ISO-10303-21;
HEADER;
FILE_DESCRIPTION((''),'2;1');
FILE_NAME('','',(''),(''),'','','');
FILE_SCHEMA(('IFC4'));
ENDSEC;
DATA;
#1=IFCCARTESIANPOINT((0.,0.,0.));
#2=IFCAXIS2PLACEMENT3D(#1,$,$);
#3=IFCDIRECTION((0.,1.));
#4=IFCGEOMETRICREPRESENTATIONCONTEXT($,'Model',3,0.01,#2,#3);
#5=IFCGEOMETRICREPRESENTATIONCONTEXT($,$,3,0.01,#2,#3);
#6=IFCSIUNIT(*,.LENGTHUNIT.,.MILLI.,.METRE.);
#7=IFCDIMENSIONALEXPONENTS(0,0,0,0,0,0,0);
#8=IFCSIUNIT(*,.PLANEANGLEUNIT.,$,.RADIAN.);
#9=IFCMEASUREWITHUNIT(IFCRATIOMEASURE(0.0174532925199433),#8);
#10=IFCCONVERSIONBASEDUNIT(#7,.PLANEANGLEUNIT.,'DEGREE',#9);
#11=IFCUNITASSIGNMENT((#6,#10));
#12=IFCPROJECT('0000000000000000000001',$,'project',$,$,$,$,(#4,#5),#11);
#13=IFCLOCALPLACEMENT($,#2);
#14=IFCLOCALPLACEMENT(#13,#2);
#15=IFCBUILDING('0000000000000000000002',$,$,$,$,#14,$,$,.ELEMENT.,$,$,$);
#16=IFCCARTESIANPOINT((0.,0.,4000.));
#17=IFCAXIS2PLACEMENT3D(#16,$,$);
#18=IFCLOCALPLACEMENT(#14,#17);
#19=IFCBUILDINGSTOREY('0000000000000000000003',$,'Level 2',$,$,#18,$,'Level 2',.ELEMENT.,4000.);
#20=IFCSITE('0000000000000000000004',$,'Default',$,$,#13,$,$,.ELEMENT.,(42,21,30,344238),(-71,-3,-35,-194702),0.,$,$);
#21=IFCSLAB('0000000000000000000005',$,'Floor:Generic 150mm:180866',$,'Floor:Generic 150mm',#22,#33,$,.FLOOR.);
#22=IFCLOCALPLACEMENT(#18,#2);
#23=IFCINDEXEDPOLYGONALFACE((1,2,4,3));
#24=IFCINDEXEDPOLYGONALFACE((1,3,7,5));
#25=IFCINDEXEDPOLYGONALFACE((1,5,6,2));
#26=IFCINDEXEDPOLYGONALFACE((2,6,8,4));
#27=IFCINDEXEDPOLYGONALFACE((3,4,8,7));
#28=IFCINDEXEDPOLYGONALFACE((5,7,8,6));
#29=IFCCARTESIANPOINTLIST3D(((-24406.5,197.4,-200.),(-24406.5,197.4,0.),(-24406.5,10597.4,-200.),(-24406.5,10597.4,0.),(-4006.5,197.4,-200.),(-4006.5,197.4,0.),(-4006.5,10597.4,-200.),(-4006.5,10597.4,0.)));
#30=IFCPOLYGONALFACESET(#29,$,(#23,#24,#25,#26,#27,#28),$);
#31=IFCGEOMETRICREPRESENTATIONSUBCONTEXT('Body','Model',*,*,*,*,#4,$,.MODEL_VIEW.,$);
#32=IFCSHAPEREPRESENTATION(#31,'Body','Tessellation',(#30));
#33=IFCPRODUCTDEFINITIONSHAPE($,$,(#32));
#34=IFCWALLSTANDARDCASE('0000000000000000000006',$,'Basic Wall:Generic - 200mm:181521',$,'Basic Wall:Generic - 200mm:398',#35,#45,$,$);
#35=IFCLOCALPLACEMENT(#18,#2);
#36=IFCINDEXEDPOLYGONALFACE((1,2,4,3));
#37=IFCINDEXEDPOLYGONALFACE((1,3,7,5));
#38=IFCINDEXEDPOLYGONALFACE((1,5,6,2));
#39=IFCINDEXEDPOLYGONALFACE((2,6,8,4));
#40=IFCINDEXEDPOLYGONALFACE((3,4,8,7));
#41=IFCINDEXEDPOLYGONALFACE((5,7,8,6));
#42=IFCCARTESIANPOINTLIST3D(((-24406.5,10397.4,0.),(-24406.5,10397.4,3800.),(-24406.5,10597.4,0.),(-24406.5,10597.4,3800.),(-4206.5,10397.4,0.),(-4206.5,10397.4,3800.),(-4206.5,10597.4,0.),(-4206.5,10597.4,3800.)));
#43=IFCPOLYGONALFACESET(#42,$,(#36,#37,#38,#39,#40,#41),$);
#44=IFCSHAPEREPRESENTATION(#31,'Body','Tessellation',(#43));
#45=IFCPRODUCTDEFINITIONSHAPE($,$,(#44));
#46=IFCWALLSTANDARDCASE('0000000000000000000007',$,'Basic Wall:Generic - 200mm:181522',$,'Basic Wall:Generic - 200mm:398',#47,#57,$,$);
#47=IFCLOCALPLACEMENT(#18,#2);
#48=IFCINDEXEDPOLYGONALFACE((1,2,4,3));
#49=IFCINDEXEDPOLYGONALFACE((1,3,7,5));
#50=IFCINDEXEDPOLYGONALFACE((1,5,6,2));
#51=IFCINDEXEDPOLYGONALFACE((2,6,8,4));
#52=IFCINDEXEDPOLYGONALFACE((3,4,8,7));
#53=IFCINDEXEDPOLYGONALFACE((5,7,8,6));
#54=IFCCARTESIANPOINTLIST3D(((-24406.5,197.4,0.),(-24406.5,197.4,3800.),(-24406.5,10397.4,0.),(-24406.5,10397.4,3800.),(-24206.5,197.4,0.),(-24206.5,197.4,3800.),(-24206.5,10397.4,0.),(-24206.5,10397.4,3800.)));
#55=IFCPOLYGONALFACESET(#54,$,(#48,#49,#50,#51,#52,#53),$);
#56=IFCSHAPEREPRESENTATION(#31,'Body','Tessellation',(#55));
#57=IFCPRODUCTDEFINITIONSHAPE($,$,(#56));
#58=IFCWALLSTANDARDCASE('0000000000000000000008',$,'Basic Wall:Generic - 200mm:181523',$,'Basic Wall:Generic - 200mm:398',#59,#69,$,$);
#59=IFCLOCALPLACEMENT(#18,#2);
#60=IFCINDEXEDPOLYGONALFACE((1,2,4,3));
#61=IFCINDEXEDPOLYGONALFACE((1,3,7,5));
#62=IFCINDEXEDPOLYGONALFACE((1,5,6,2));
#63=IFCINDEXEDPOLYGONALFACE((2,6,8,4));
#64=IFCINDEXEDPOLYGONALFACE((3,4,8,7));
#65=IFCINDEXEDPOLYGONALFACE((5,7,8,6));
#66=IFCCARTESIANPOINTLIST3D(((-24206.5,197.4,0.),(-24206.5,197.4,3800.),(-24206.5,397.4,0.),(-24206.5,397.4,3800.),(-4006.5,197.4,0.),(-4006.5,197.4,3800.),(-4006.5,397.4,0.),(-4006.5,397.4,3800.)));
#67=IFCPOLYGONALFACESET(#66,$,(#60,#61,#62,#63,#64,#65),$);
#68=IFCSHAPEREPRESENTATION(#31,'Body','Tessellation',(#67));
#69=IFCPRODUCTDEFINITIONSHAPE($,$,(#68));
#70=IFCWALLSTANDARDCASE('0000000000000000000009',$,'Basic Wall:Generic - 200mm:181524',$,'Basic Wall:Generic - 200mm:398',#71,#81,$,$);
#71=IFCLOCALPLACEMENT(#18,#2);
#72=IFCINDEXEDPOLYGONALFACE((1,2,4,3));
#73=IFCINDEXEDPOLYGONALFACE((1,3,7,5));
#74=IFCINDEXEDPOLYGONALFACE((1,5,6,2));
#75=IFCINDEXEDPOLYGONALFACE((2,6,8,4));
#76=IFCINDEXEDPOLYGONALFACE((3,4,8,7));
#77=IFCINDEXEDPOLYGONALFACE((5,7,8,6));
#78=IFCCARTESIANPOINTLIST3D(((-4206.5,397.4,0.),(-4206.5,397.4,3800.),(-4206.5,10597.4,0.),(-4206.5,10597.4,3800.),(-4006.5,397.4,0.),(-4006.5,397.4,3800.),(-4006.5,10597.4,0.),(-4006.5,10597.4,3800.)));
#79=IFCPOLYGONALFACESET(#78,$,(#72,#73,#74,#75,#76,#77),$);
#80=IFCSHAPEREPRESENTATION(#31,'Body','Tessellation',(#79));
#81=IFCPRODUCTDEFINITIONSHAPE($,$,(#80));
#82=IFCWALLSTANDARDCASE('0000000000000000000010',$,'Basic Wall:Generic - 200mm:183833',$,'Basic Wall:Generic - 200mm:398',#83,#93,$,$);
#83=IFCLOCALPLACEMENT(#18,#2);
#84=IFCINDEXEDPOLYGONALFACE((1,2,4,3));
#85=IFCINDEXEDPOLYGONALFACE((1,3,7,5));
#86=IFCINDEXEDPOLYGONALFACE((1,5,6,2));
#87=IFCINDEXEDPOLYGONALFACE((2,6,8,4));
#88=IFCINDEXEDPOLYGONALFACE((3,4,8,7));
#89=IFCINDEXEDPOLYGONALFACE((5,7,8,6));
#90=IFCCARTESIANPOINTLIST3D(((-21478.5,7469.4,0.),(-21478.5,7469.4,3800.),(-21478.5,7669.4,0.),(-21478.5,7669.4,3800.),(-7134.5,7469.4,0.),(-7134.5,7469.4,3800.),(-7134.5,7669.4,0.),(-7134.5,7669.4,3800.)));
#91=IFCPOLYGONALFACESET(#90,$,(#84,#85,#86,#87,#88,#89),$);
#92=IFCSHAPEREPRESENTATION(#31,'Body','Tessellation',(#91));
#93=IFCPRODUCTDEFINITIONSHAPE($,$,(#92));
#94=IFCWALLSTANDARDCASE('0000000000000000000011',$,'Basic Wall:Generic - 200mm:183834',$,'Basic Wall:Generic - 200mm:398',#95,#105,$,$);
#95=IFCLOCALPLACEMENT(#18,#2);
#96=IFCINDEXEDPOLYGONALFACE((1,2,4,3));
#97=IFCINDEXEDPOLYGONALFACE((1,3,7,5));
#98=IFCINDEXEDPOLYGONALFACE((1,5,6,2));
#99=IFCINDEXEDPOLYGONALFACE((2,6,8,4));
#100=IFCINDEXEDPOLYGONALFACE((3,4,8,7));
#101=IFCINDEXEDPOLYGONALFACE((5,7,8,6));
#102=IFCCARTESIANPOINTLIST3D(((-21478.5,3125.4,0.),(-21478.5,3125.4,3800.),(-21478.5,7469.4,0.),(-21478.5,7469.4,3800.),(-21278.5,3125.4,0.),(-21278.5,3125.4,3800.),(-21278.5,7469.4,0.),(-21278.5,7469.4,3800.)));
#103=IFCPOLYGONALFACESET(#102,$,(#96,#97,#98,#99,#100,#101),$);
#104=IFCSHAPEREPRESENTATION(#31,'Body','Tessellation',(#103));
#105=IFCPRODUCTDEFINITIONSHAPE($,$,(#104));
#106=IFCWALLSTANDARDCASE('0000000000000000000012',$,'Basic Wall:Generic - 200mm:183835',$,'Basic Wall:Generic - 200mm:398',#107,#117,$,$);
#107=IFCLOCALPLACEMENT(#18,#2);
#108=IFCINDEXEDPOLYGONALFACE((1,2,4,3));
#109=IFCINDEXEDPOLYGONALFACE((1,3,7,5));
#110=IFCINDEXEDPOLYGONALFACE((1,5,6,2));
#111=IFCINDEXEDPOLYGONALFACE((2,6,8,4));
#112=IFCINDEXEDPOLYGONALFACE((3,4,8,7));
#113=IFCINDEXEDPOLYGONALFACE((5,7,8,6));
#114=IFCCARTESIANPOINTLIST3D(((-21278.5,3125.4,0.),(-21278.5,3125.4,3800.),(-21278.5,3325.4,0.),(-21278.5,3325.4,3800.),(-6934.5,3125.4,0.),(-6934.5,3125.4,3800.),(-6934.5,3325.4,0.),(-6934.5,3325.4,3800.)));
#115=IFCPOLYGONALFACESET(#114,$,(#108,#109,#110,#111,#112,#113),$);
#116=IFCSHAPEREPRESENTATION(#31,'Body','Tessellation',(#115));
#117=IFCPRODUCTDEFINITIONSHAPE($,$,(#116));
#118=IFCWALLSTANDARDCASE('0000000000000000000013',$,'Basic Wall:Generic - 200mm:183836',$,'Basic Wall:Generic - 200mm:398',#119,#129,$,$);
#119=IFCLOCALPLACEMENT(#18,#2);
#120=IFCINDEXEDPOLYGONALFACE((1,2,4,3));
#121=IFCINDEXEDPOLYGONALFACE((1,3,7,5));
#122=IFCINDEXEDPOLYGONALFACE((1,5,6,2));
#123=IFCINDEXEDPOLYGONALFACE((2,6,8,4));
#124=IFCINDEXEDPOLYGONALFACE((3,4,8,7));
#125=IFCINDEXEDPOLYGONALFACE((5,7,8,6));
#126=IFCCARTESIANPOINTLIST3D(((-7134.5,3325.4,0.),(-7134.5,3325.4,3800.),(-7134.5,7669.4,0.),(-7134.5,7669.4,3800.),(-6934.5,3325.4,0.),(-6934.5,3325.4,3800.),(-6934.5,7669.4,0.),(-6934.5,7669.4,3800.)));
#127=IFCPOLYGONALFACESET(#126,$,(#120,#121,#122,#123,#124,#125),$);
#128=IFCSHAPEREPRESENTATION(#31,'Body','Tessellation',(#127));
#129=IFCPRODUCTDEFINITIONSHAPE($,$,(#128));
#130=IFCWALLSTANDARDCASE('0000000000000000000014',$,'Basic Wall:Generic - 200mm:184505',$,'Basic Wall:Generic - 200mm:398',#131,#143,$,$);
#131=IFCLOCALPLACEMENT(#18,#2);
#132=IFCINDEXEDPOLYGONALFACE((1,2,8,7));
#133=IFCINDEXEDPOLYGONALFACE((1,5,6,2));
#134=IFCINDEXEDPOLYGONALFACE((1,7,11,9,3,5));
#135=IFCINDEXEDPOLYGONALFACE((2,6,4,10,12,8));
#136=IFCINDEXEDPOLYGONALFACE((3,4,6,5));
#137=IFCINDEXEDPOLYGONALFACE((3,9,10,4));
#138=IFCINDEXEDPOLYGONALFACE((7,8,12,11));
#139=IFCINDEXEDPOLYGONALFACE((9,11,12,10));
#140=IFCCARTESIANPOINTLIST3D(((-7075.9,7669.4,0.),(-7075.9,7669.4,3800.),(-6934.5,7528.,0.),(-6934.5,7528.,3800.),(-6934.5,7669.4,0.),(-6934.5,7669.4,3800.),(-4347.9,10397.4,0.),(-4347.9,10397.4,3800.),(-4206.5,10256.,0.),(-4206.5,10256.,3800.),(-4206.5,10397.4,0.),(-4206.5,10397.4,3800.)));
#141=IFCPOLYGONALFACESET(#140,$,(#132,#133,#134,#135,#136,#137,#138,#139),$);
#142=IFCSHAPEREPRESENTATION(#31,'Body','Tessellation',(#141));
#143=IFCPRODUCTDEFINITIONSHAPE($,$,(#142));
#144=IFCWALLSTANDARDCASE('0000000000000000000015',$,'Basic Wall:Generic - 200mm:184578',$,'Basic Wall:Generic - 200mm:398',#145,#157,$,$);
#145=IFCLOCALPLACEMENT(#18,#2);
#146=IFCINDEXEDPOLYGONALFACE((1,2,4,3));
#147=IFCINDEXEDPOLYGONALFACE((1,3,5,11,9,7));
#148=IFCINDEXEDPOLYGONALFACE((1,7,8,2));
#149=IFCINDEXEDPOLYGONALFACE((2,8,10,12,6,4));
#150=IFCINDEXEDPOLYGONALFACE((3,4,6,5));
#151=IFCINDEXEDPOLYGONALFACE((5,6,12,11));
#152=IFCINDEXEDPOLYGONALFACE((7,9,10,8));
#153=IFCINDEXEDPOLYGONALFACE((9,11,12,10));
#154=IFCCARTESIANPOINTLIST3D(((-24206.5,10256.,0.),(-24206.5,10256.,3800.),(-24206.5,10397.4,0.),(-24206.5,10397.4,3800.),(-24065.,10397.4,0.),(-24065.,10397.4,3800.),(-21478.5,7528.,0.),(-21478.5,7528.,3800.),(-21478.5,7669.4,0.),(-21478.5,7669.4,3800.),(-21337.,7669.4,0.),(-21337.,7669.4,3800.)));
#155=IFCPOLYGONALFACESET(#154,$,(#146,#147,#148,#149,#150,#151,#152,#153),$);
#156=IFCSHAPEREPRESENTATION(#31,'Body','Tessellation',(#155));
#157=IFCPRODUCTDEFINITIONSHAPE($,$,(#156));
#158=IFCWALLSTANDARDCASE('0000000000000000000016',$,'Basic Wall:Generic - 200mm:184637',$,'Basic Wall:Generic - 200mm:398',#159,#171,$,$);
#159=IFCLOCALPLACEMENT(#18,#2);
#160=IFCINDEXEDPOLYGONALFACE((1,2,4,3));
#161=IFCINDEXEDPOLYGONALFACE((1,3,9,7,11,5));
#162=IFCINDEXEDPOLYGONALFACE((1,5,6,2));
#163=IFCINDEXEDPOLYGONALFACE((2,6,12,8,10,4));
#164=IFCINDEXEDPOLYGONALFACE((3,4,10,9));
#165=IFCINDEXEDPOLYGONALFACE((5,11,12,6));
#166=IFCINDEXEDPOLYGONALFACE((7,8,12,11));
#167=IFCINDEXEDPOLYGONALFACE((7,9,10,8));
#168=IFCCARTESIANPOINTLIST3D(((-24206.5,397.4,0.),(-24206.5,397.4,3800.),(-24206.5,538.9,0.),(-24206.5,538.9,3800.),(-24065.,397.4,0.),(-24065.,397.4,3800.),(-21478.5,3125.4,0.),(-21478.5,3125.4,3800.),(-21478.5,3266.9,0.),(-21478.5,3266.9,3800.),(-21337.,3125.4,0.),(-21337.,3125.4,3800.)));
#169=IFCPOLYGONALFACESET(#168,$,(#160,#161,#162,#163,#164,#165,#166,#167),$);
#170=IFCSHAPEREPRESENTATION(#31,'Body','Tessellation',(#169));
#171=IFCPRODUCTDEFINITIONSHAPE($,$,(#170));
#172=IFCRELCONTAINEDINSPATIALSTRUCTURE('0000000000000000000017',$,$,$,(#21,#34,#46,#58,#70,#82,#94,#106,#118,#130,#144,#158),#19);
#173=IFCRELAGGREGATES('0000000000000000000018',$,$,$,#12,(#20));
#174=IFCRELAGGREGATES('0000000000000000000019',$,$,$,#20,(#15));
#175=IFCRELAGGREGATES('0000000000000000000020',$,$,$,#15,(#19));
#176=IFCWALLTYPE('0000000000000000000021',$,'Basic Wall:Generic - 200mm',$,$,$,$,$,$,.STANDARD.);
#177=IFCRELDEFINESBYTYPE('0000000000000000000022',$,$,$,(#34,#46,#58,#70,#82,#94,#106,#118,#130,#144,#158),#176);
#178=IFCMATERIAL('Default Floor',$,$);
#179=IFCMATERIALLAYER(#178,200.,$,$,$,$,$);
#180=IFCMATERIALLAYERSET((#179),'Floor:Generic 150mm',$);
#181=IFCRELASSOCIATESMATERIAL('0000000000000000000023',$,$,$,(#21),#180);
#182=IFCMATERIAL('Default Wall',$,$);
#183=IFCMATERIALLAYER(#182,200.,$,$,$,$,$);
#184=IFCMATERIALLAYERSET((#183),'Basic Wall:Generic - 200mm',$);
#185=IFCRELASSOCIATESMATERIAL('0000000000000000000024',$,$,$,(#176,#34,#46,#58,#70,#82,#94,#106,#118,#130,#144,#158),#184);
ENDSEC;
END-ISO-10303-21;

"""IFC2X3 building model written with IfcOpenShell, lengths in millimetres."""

from ifc_helpers import new_model, entity, si_unit, converted_unit, direction, frame, frame_2d, origin, origin_2d_with_axis, place, context, subcontext, project, spatial, polyline, rectangle, outline, extrude, material, layer, layer_set, layer_usage, type_object, element, save


model = new_model("IFC2X3")

# Units and contexts
model_context = context("Model", 3, precision=0.01, world=origin(), true_north=direction((0.0, 1.0)))
context_of_model = context(None, 3, precision=0.01, world=origin(), true_north=direction((0.0, 1.0)))
body_context = subcontext(model_context, "Body", "Model", "MODEL_VIEW")
ifc_project = project(units=[si_unit("LENGTHUNIT", "METRE", prefix="MILLI"), converted_unit("PLANEANGLEUNIT", "DEGREE", entity("IfcRatioMeasure", 0.0174532925199433), si_unit("PLANEANGLEUNIT", "RADIAN"), dimensions=[0, 0, 0, 0, 0, 0, 0])], contexts=[model_context, context_of_model])

# Site, building, storey
site_placement = place(None, origin())
site = spatial("IfcSite", under=ifc_project, at=site_placement, Name="Default", CompositionType="ELEMENT", RefLatitude=(42, 21, 30, 344238), RefLongitude=(-71, -3, -35, -194702), RefElevation=0.0)
building_placement = place(site_placement, origin())
building = spatial("IfcBuilding", under=site, at=building_placement, CompositionType="ELEMENT")
storey_placement = place(building_placement, frame((0.0, 0.0, 4000.0)))
storey = spatial("IfcBuildingStorey", under=building, at=storey_placement, Name="Level 2", LongName="Level 2", CompositionType="ELEMENT", Elevation=4000.0)

# Slab
ifc_material_1 = material(Name="Default Floor")
ifc_layer_1 = layer(ifc_material_1, 200.0)
ifc_layer_set_1 = layer_set([ifc_layer_1], Name="Floor:Generic 150mm")
ifc_layer_usage_1 = layer_usage(ifc_layer_set_1, "AXIS3", "POSITIVE", 0.0)
slab_placement = place(storey_placement, origin())
element("IfcSlab", 1, at=slab_placement, inside=storey, material=ifc_layer_usage_1, Name="Floor:Generic 150mm:180866", ObjectType="Floor:Generic 150mm", PredefinedType="FLOOR", context=body_context, shape_type="SweptSolid", body=[
    extrude(rectangle(XDim=10400.0, YDim=20400.0, at=origin_2d_with_axis()), frame((-14206.5, 5397.4, 0.0), z_axis=(0.0, 0.0, -1.0), x_axis=(0.0, 1.0, 0.0)), (0.0, 0.0, 1.0), 200.0),
])

# Walls
ifc_material_2 = material(Name="Default Wall")
ifc_layer_2 = layer(ifc_material_2, 200.0)
ifc_layer_set_2 = layer_set([ifc_layer_2], Name="Basic Wall:Generic - 200mm")
ifc_layer_usage_2 = layer_usage(ifc_layer_set_2, "AXIS2", "NEGATIVE", 100.0)
wall_type = type_object("IfcWallType", Name="Basic Wall:Generic - 200mm", PredefinedType="STANDARD", material=ifc_layer_set_2)
wall_1_placement = place(storey_placement, frame((-24406.5, 10497.4, 0.0)))
element("IfcWallStandardCase", 2, at=wall_1_placement, inside=storey, type_object=wall_type, material=ifc_layer_usage_2, Name="Basic Wall:Generic - 200mm:181521", ObjectType="Basic Wall:Generic - 200mm:398", context=body_context, shape_type="SweptSolid", body=[
    extrude(rectangle(XDim=20200.0, YDim=200.0, at=frame_2d((10100.0, 0.0), x_axis=(-1.0, 0.0))), origin(), (0.0, 0.0, 1.0), 3800.0),
])
ifc_layer_usage_3 = layer_usage(ifc_layer_set_2, "AXIS2", "NEGATIVE", 100.0)
wall_2_placement = place(storey_placement, frame((-24306.5, 197.4, 0.0), z_axis=(0.0, 0.0, 1.0), x_axis=(0.0, 1.0, 0.0)))
element("IfcWallStandardCase", 3, at=wall_2_placement, inside=storey, type_object=wall_type, material=ifc_layer_usage_3, Name="Basic Wall:Generic - 200mm:181522", ObjectType="Basic Wall:Generic - 200mm:398", context=body_context, shape_type="SweptSolid", body=[
    extrude(rectangle(XDim=10200.0, YDim=200.0, at=frame_2d((5100.0, 0.0), x_axis=(-1.0, 0.0))), origin(), (0.0, 0.0, 1.0), 3800.0),
])
ifc_layer_usage_4 = layer_usage(ifc_layer_set_2, "AXIS2", "NEGATIVE", 100.0)
wall_3_placement = place(storey_placement, frame((-4006.5, 297.4, 0.0), z_axis=(0.0, 0.0, 1.0), x_axis=(-1.0, 0.0, 0.0)))
element("IfcWallStandardCase", 4, at=wall_3_placement, inside=storey, type_object=wall_type, material=ifc_layer_usage_4, Name="Basic Wall:Generic - 200mm:181523", ObjectType="Basic Wall:Generic - 200mm:398", context=body_context, shape_type="SweptSolid", body=[
    extrude(rectangle(XDim=20200.0, YDim=200.0, at=frame_2d((10100.0, 0.0), x_axis=(-1.0, 0.0))), origin(), (0.0, 0.0, 1.0), 3800.0),
])
ifc_layer_usage_5 = layer_usage(ifc_layer_set_2, "AXIS2", "NEGATIVE", 100.0)
wall_4_placement = place(storey_placement, frame((-4106.5, 10597.4, 0.0), z_axis=(0.0, 0.0, 1.0), x_axis=(0.0, -1.0, 0.0)))
element("IfcWallStandardCase", 5, at=wall_4_placement, inside=storey, type_object=wall_type, material=ifc_layer_usage_5, Name="Basic Wall:Generic - 200mm:181524", ObjectType="Basic Wall:Generic - 200mm:398", context=body_context, shape_type="SweptSolid", body=[
    extrude(rectangle(XDim=10200.0, YDim=200.0, at=frame_2d((5100.0, 0.0), x_axis=(-1.0, 0.0))), origin(), (0.0, 0.0, 1.0), 3800.0),
])
ifc_layer_usage_6 = layer_usage(ifc_layer_set_2, "AXIS2", "NEGATIVE", 100.0)
wall_5_placement = place(storey_placement, frame((-21478.5, 7569.4, 0.0)))
element("IfcWallStandardCase", 6, at=wall_5_placement, inside=storey, type_object=wall_type, material=ifc_layer_usage_6, Name="Basic Wall:Generic - 200mm:183833", ObjectType="Basic Wall:Generic - 200mm:398", context=body_context, shape_type="SweptSolid", body=[
    extrude(rectangle(XDim=14344.0, YDim=200.0, at=frame_2d((7172.0, 0.0), x_axis=(-1.0, 0.0))), origin(), (0.0, 0.0, 1.0), 3800.0),
])
ifc_layer_usage_7 = layer_usage(ifc_layer_set_2, "AXIS2", "NEGATIVE", 100.0)
wall_6_placement = place(storey_placement, frame((-21378.5, 3125.4, 0.0), z_axis=(0.0, 0.0, 1.0), x_axis=(0.0, 1.0, 0.0)))
element("IfcWallStandardCase", 7, at=wall_6_placement, inside=storey, type_object=wall_type, material=ifc_layer_usage_7, Name="Basic Wall:Generic - 200mm:183834", ObjectType="Basic Wall:Generic - 200mm:398", context=body_context, shape_type="SweptSolid", body=[
    extrude(rectangle(XDim=4344.0, YDim=200.0, at=frame_2d((2172.0, 0.0), x_axis=(-1.0, 0.0))), origin(), (0.0, 0.0, 1.0), 3800.0),
])
ifc_layer_usage_8 = layer_usage(ifc_layer_set_2, "AXIS2", "NEGATIVE", 100.0)
wall_7_placement = place(storey_placement, frame((-6934.5, 3225.4, 0.0), z_axis=(0.0, 0.0, 1.0), x_axis=(-1.0, 0.0, 0.0)))
element("IfcWallStandardCase", 8, at=wall_7_placement, inside=storey, type_object=wall_type, material=ifc_layer_usage_8, Name="Basic Wall:Generic - 200mm:183835", ObjectType="Basic Wall:Generic - 200mm:398", context=body_context, shape_type="SweptSolid", body=[
    extrude(rectangle(XDim=14344.0, YDim=200.0, at=frame_2d((7172.0, 0.0), x_axis=(-1.0, 0.0))), origin(), (0.0, 0.0, 1.0), 3800.0),
])
ifc_layer_usage_9 = layer_usage(ifc_layer_set_2, "AXIS2", "NEGATIVE", 100.0)
wall_8_placement = place(storey_placement, frame((-7034.5, 7669.4, 0.0), z_axis=(0.0, 0.0, 1.0), x_axis=(0.0, -1.0, 0.0)))
element("IfcWallStandardCase", 9, at=wall_8_placement, inside=storey, type_object=wall_type, material=ifc_layer_usage_9, Name="Basic Wall:Generic - 200mm:183836", ObjectType="Basic Wall:Generic - 200mm:398", context=body_context, shape_type="SweptSolid", body=[
    extrude(rectangle(XDim=4344.0, YDim=200.0, at=frame_2d((2172.0, 0.0), x_axis=(-1.0, 0.0))), origin(), (0.0, 0.0, 1.0), 3800.0),
])
ifc_layer_usage_10 = layer_usage(ifc_layer_set_2, "AXIS2", "NEGATIVE", 100.0)
wall_9_placement = place(storey_placement, frame((-7005.2, 7598.7, 0.0), z_axis=(0.0, 0.0, 1.0), x_axis=(0.707107, 0.707107, 0.0)))
element("IfcWallStandardCase", 10, at=wall_9_placement, inside=storey, type_object=wall_type, material=ifc_layer_usage_10, Name="Basic Wall:Generic - 200mm:184505", ObjectType="Basic Wall:Generic - 200mm:398", context=body_context, shape_type="SweptSolid", body=[
    extrude(outline(polyline([(3858.0, -100.0), (3958.0, 0.0), (3858.0, 100.0), (0.0, 100.0), (100.0, 0.0), (0.0, -100.0), (3858.0, -100.0)])), origin(), (0.0, 0.0, 1.0), 3800.0),
])
ifc_layer_usage_11 = layer_usage(ifc_layer_set_2, "AXIS2", "NEGATIVE", 100.0)
wall_10_placement = place(storey_placement, frame((-21407.8, 7598.7, 0.0), z_axis=(0.0, 0.0, 1.0), x_axis=(-0.707107, 0.707107, 0.0)))
element("IfcWallStandardCase", 11, at=wall_10_placement, inside=storey, type_object=wall_type, material=ifc_layer_usage_11, Name="Basic Wall:Generic - 200mm:184578", ObjectType="Basic Wall:Generic - 200mm:398", context=body_context, shape_type="SweptSolid", body=[
    extrude(outline(polyline([(3858.0, -100.0), (3958.0, 0.0), (3858.0, 100.0), (0.0, 100.0), (100.0, 0.0), (0.0, -100.0), (3858.0, -100.0)])), origin(), (0.0, 0.0, 1.0), 3800.0),
])
ifc_layer_usage_12 = layer_usage(ifc_layer_set_2, "AXIS2", "NEGATIVE", 100.0)
wall_11_placement = place(storey_placement, frame((-21407.8, 3196.2, 0.0), z_axis=(0.0, 0.0, 1.0), x_axis=(-0.707107, -0.707107, 0.0)))
element("IfcWallStandardCase", 12, at=wall_11_placement, inside=storey, type_object=wall_type, material=ifc_layer_usage_12, Name="Basic Wall:Generic - 200mm:184637", ObjectType="Basic Wall:Generic - 200mm:398", context=body_context, shape_type="SweptSolid", body=[
    extrude(outline(polyline([(3858.0, -100.0), (3958.0, 0.0), (3858.0, 100.0), (0.0, 100.0), (100.0, 0.0), (0.0, -100.0), (3858.0, -100.0)])), origin(), (0.0, 0.0, 1.0), 3800.0),
])

save(model, "model.ifc")
